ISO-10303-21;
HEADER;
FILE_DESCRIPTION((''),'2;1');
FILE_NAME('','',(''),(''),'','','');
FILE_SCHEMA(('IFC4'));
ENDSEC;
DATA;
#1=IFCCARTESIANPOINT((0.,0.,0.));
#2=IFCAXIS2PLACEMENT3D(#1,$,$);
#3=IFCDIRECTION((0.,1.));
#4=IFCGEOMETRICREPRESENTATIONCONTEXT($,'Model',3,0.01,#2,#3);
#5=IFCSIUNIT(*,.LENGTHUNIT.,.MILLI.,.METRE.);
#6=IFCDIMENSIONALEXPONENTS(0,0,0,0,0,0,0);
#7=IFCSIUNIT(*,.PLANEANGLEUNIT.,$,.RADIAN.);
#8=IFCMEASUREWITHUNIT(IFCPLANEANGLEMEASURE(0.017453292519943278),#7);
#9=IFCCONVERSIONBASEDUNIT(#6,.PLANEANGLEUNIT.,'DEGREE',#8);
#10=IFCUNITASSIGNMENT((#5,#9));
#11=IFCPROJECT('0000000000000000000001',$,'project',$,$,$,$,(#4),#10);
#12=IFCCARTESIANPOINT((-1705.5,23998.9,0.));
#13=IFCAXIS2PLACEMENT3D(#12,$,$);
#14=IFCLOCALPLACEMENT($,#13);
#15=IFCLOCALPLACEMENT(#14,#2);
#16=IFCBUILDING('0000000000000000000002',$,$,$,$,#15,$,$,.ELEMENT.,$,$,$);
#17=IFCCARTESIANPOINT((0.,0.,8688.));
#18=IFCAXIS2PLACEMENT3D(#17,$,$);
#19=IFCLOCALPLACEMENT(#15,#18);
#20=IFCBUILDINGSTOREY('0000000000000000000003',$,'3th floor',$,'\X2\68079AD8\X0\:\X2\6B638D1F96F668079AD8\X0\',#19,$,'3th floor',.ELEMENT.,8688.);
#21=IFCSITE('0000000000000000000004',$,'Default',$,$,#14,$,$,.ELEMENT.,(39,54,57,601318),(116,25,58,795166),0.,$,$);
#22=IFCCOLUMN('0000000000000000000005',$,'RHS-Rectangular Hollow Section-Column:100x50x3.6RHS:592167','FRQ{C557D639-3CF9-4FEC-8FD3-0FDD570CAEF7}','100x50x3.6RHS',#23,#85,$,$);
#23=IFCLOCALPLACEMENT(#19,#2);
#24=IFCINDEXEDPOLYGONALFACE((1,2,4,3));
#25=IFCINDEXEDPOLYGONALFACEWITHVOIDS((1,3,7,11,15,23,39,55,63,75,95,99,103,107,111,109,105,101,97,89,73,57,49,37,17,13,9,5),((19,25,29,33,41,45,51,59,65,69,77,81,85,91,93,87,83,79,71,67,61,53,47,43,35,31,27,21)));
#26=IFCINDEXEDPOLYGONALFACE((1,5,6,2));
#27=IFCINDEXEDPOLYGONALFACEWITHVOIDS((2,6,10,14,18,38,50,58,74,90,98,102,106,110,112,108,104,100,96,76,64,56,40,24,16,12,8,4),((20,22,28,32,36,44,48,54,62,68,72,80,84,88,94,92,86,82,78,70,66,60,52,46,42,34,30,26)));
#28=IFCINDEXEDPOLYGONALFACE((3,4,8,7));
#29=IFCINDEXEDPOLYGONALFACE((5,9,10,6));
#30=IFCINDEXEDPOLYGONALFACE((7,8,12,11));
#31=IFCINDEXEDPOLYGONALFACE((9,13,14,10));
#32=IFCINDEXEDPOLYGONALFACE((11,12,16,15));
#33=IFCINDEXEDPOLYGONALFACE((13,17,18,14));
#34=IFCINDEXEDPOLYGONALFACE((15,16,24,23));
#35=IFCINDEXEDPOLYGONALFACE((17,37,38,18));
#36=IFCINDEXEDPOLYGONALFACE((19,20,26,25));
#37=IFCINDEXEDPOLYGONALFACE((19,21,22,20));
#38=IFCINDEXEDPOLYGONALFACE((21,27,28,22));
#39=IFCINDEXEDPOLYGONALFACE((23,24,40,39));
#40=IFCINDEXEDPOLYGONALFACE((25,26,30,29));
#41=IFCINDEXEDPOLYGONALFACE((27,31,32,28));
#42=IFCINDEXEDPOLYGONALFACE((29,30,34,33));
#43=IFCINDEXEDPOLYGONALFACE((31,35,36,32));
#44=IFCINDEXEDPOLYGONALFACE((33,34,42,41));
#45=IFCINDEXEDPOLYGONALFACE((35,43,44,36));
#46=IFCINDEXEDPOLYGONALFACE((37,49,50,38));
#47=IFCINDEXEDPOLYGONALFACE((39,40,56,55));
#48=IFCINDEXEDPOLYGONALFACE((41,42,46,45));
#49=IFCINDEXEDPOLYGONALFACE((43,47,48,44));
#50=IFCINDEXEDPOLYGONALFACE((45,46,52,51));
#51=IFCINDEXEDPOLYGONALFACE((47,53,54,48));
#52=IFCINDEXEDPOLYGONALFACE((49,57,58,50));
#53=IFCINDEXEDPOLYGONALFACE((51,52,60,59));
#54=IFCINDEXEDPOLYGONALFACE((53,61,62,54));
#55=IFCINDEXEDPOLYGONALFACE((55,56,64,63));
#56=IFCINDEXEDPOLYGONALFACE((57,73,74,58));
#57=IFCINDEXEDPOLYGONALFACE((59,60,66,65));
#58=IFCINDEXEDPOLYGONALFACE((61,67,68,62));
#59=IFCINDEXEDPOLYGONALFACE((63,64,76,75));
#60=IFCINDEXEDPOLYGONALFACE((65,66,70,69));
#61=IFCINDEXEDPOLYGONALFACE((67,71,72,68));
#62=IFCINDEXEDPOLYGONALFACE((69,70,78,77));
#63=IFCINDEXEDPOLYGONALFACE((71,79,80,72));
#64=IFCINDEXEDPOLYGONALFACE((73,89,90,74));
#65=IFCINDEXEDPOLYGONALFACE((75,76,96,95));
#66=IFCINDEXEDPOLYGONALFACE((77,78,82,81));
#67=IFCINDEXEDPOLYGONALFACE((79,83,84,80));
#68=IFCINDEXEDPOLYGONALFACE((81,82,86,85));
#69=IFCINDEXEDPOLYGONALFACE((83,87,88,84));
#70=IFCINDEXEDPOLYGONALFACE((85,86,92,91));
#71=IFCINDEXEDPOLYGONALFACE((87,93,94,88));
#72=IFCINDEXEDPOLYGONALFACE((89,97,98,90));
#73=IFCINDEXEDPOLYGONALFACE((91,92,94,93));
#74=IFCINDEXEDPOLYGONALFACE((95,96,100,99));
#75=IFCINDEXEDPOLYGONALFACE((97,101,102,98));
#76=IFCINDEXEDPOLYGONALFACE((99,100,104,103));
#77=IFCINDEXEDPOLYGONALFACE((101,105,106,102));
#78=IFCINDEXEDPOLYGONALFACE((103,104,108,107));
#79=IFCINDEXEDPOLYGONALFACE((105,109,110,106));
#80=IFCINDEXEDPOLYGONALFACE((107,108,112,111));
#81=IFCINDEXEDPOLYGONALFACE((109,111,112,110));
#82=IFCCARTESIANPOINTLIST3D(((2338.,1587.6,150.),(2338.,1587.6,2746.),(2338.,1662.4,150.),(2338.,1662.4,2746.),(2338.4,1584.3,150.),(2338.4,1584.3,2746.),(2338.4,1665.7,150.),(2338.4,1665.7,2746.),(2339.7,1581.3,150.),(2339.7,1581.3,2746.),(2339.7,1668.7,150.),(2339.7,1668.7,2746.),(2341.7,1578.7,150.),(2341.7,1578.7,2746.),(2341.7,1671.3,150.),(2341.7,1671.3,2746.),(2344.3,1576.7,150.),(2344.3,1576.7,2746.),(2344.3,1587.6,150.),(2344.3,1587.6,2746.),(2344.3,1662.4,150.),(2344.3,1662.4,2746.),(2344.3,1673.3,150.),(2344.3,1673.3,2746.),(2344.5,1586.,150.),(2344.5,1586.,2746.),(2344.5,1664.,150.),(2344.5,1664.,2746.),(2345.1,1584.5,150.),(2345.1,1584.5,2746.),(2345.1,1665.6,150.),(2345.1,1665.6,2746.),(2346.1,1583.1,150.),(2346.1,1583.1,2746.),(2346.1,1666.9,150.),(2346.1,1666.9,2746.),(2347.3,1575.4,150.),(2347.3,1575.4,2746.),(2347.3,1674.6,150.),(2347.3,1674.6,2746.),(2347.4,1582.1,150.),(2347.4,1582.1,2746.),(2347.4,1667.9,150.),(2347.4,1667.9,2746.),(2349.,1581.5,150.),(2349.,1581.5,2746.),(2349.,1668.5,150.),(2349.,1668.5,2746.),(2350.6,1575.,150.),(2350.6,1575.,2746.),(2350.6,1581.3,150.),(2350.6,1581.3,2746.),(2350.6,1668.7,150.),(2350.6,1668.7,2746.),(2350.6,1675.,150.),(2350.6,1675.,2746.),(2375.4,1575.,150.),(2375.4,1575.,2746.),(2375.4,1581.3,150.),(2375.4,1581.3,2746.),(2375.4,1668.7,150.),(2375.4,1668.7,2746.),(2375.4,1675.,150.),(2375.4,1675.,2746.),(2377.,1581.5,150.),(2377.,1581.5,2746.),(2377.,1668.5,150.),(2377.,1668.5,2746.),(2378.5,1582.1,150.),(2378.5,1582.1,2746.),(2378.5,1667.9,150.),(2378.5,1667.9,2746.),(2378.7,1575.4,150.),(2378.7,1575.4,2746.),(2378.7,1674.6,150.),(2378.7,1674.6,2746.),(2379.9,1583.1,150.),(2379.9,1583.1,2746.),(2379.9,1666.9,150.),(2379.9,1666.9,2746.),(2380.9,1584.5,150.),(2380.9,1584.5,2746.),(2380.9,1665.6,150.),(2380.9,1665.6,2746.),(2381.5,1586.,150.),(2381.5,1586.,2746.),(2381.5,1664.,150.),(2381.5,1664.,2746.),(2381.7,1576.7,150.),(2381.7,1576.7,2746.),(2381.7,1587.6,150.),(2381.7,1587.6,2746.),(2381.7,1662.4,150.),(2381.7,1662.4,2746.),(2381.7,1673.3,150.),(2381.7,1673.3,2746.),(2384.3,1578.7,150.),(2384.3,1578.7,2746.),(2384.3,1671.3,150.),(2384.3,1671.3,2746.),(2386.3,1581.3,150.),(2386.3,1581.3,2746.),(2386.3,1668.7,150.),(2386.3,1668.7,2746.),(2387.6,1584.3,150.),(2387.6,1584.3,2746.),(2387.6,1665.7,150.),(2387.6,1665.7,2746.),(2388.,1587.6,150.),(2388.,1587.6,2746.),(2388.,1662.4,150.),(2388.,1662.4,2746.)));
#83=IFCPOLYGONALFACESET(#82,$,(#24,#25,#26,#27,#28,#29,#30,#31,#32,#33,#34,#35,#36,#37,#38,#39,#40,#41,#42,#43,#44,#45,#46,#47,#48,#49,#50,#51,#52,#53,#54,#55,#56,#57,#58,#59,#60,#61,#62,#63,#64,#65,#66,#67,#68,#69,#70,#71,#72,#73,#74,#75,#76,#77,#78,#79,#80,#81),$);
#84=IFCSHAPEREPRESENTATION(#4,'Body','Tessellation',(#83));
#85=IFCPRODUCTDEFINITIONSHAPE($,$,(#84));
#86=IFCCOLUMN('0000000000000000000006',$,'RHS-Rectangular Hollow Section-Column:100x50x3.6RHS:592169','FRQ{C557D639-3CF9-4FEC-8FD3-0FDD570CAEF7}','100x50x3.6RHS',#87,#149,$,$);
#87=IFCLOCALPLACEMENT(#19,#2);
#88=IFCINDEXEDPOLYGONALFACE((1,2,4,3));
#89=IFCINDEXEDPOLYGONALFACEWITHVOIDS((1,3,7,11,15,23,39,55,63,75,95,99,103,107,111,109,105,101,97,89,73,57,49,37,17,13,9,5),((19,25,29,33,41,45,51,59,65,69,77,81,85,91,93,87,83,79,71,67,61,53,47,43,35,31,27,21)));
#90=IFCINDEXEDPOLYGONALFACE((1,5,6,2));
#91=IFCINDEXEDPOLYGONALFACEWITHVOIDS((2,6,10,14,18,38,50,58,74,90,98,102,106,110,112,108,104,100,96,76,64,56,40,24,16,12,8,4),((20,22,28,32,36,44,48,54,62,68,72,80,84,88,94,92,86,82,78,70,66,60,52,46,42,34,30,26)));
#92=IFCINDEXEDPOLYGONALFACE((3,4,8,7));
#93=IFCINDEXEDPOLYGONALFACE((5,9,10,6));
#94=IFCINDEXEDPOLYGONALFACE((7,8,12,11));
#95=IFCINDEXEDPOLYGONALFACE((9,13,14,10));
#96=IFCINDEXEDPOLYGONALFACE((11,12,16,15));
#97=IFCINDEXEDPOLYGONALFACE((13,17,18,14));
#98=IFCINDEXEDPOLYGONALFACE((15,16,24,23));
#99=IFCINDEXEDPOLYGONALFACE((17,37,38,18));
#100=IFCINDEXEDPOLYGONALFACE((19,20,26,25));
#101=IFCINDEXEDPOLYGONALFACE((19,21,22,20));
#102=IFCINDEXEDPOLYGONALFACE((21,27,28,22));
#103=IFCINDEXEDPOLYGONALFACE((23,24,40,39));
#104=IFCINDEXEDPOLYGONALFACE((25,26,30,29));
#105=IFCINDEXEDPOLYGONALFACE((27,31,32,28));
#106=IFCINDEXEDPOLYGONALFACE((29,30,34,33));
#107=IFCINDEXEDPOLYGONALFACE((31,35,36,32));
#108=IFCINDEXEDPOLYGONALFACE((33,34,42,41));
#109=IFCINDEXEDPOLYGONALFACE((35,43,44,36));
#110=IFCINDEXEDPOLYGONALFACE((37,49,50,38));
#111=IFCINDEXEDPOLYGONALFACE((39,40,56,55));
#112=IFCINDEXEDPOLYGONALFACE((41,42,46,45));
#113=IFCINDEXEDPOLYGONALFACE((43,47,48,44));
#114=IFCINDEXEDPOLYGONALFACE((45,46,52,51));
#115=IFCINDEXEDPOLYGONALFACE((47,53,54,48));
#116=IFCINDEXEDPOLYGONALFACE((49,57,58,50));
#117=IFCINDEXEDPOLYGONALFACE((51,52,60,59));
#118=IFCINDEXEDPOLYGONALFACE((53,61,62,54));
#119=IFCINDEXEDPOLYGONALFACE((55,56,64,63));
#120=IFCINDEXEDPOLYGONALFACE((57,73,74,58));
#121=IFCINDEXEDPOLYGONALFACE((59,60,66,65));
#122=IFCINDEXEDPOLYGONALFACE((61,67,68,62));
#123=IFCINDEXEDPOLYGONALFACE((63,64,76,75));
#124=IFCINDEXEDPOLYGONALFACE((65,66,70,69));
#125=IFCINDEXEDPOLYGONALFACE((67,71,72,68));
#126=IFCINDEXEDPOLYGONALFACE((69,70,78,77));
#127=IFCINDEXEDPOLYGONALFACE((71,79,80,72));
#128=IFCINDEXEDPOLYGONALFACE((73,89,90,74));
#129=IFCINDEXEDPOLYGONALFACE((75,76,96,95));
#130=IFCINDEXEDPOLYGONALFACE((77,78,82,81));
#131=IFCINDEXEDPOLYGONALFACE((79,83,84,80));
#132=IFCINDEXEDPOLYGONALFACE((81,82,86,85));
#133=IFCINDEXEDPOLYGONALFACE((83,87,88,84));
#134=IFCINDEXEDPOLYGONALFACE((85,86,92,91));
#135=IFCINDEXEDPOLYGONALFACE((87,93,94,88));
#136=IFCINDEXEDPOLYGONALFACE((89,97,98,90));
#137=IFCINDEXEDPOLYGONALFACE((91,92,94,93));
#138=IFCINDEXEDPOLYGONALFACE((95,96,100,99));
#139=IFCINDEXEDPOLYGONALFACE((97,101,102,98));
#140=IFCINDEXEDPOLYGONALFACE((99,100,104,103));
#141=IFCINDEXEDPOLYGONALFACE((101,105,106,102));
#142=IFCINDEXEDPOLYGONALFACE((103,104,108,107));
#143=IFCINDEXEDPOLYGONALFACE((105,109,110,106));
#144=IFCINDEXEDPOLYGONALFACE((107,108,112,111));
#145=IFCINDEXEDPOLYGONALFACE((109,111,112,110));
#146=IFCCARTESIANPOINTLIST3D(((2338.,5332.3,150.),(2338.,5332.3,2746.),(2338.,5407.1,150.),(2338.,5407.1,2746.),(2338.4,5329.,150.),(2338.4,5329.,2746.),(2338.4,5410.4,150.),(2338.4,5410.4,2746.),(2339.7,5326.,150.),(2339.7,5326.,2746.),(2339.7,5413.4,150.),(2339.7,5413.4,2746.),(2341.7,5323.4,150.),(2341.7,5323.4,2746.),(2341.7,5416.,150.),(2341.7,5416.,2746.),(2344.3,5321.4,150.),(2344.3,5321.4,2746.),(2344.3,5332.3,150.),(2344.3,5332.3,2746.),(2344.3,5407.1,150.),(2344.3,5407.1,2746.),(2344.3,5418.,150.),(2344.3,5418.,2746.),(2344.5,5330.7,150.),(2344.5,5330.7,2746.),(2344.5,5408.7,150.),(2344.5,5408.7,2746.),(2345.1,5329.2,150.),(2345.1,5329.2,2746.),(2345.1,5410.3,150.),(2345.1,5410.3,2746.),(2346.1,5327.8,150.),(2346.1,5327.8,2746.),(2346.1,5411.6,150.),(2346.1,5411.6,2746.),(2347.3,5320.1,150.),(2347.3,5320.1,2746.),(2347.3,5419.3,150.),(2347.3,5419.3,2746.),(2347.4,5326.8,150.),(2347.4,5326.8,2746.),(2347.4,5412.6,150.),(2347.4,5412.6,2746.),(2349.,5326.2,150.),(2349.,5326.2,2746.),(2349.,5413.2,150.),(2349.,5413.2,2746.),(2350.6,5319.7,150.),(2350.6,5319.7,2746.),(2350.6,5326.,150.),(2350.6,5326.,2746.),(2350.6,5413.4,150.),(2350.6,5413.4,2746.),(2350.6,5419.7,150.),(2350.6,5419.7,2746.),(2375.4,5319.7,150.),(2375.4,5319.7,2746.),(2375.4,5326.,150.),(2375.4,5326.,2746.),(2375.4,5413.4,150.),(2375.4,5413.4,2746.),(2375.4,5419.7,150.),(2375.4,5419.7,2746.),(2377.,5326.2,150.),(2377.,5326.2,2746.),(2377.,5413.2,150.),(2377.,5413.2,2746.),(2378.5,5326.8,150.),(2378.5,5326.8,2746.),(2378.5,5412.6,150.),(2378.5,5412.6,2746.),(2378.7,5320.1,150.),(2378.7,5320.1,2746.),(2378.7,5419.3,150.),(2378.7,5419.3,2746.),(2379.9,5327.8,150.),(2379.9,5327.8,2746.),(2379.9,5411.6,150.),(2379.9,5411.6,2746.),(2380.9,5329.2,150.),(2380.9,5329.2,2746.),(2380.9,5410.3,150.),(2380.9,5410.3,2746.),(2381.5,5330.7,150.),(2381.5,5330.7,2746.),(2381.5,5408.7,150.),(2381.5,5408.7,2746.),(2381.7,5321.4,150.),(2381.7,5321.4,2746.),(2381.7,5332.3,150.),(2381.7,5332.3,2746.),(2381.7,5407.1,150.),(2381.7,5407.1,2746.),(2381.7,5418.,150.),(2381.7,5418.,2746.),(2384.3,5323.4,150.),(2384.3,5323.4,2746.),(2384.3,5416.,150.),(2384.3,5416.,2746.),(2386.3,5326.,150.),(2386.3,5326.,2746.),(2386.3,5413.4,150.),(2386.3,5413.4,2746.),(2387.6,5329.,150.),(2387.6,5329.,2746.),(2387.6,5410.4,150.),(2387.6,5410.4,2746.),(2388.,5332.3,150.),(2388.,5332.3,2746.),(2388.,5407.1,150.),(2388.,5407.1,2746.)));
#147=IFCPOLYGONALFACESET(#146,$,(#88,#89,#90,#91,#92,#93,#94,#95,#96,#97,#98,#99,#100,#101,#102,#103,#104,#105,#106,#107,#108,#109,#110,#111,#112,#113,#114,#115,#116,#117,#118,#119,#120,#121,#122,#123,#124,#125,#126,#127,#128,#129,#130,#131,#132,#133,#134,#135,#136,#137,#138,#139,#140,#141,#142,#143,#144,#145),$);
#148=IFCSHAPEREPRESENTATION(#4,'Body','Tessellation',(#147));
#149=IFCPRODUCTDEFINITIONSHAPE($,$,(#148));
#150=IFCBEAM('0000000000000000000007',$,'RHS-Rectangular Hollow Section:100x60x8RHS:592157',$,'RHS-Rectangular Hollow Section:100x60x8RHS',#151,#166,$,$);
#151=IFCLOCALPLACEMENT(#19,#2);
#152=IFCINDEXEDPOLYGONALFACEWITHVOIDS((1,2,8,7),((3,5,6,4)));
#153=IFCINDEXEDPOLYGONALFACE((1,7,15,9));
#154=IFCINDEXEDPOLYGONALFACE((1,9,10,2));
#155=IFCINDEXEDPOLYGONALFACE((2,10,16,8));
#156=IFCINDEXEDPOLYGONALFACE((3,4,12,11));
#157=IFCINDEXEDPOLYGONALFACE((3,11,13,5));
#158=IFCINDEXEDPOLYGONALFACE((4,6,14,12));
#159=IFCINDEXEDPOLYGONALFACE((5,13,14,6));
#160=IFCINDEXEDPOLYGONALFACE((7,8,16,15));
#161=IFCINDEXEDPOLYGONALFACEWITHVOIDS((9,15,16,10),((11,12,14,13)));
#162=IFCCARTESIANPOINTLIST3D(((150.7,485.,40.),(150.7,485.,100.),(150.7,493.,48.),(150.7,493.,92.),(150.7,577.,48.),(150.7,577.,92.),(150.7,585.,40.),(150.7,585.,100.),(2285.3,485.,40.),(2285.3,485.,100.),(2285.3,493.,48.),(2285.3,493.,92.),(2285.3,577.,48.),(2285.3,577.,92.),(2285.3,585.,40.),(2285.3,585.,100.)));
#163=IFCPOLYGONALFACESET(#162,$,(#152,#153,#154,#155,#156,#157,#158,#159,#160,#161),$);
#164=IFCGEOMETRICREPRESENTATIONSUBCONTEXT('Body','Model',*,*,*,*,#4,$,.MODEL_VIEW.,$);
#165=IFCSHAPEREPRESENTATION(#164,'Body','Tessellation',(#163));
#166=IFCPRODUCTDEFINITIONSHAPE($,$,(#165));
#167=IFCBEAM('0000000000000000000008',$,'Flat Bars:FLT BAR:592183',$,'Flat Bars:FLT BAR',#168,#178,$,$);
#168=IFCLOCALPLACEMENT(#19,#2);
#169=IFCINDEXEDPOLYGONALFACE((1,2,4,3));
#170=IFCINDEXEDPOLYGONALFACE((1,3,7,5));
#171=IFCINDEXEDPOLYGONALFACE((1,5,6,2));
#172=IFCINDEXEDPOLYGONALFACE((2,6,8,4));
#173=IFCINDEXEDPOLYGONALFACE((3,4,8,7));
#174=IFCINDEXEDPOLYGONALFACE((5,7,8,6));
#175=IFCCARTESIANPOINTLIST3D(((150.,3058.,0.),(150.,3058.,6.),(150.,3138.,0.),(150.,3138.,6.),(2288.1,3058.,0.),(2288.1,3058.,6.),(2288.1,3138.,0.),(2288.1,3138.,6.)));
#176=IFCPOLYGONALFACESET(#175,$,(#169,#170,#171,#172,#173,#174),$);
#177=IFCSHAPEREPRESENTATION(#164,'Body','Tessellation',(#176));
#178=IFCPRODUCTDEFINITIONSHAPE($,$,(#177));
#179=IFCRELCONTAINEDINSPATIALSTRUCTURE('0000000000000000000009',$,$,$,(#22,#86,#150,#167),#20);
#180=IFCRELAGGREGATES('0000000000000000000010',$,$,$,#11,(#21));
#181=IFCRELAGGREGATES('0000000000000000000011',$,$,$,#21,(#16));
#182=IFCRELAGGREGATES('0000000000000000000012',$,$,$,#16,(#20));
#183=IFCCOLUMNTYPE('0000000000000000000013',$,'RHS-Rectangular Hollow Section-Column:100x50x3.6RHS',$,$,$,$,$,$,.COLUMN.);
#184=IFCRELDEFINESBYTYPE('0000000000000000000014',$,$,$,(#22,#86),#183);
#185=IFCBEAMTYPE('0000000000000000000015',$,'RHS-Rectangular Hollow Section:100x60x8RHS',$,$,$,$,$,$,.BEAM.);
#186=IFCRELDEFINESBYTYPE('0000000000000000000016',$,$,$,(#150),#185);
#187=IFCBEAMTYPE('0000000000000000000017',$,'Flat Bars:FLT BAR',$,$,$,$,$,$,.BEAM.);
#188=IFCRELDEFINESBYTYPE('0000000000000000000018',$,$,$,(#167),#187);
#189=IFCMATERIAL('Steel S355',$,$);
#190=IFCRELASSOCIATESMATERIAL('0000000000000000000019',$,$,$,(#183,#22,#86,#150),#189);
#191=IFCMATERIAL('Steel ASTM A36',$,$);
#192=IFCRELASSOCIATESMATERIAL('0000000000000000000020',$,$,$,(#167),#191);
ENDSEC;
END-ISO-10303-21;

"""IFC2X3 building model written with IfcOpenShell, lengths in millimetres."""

from ifc_helpers import new_model, entity, si_unit, converted_unit, direction, frame, frame_2d, origin, origin_2d, origin_2d_with_axis, place, context, subcontext, project, spatial, rectangle, hollow_rectangle, extrude, boolean, clip, halfspace, material, type_object, element, save


model = new_model("IFC2X3")

# Units and contexts
model_context = context("Model", 3, precision=0.01, world=origin(), true_north=direction((0.0, 1.0)))
body_context = subcontext(model_context, "Body", "Model", "MODEL_VIEW")
ifc_project = project(units=[si_unit("LENGTHUNIT", "METRE", prefix="MILLI"), converted_unit("PLANEANGLEUNIT", "DEGREE", entity("IfcPlaneAngleMeasure", 0.017453292519943278), si_unit("PLANEANGLEUNIT", "RADIAN"), dimensions=[0, 0, 0, 0, 0, 0, 0])], contexts=[model_context])

# Site, building, storey
site_placement = place(None, frame((-1705.5, 23998.9, 0.0)))
site = spatial("IfcSite", under=ifc_project, at=site_placement, Name="Default", CompositionType="ELEMENT", RefLatitude=(39, 54, 57, 601318), RefLongitude=(116, 25, 58, 795166), RefElevation=0.0)
building_placement = place(site_placement, origin())
building = spatial("IfcBuilding", under=site, at=building_placement, CompositionType="ELEMENT")
storey_placement = place(building_placement, frame((0.0, 0.0, 8688.0)))
storey = spatial("IfcBuildingStorey", under=building, at=storey_placement, Name="3th floor", ObjectType="标高:正负零标高", LongName="3th floor", CompositionType="ELEMENT", Elevation=8688.0)

# Shared definitions
ifc_material_1 = material(Name="Steel S355")

# Columns
column_type_1 = type_object("IfcColumnType", Name="RHS-Rectangular Hollow Section-Column:100x50x3.6RHS", PredefinedType="COLUMN", material=ifc_material_1)
column_1_placement = place(storey_placement, frame((2363.0, 1625.0, 2746.0), z_axis=(0.0, 0.0, 1.0), x_axis=(-1.0, 0.0, 0.0)))
element("IfcColumn", 1, at=column_1_placement, inside=storey, type_object=column_type_1, material=ifc_material_1, Name="RHS-Rectangular Hollow Section-Column:100x50x3.6RHS:592167", Description="FRQ{C557D639-3CF9-4FEC-8FD3-0FDD570CAEF7}", ObjectType="100x50x3.6RHS", context=model_context, shape_type="Clipping", body=[
    clip(extrude(hollow_rectangle(XDim=50.0, YDim=100.0, WallThickness=6.3, InnerFilletRadius=6.3, OuterFilletRadius=12.6, at=origin_2d()), origin(), (0.0, 0.0, -1.0), 2651.9), halfspace(frame((2363.0, 1625.0, -2596.0), z_axis=(0.0, 0.0, 1.0), x_axis=(-1.0, 0.0, 0.0)), True)),
])
column_2_placement = place(storey_placement, frame((2363.0, 5369.7, 2746.0), z_axis=(0.0, 0.0, 1.0), x_axis=(-1.0, 0.0, 0.0)))
element("IfcColumn", 2, at=column_2_placement, inside=storey, type_object=column_type_1, material=ifc_material_1, Name="RHS-Rectangular Hollow Section-Column:100x50x3.6RHS:592169", Description="FRQ{C557D639-3CF9-4FEC-8FD3-0FDD570CAEF7}", ObjectType="100x50x3.6RHS", context=model_context, shape_type="Clipping", body=[
    clip(extrude(hollow_rectangle(XDim=50.0, YDim=100.0, WallThickness=6.3, InnerFilletRadius=6.3, OuterFilletRadius=12.6, at=origin_2d()), origin(), (0.0, 0.0, -1.0), 2651.9), halfspace(frame((2363.0, 5369.7, -2596.0), z_axis=(0.0, 0.0, 1.0), x_axis=(-1.0, 0.0, 0.0)), True)),
])

# Beams
beam_type_1 = type_object("IfcBeamType", Name="RHS-Rectangular Hollow Section:100x60x8RHS", PredefinedType="BEAM")
beam_1_placement = place(storey_placement, frame((150.7, 585.0, 70.0)))
element("IfcBeam", 3, at=beam_1_placement, inside=storey, type_object=beam_type_1, material=ifc_material_1, Name="RHS-Rectangular Hollow Section:100x60x8RHS:592157", ObjectType="RHS-Rectangular Hollow Section:100x60x8RHS", context=body_context, shape_type="SweptSolid", body=[
    boolean("DIFFERENCE", extrude(rectangle(XDim=60.0, YDim=100.0, at=frame_2d((0.0, 0.0), x_axis=(1.0, 0.0))), frame((0.0, -50.0, 0.0), z_axis=(1.0, 0.0, 0.0), x_axis=(0.0, 0.0, -1.0)), (0.0, 0.0, 1.0), 2134.6), extrude(rectangle(XDim=44.0, YDim=84.0, at=frame_2d((0.0, 0.0), x_axis=(0.0, 1.0))), frame((2134.6, -50.0, 0.0), z_axis=(-1.0, 0.0, 0.0), x_axis=(0.0, 1.0, 0.0)), (0.0, 0.0, 1.0), 2134.6)),
])
ifc_material_2 = material(Name="Steel ASTM A36")
beam_type_2 = type_object("IfcBeamType", Name="Flat Bars:FLT BAR", PredefinedType="BEAM")
beam_2_placement = place(storey_placement, frame((150.0, 3098.0, 6.0)))
element("IfcBeam", 4, at=beam_2_placement, inside=storey, type_object=beam_type_2, material=ifc_material_2, Name="Flat Bars:FLT BAR:592183", ObjectType="Flat Bars:FLT BAR", context=body_context, shape_type="SweptSolid", body=[
    extrude(rectangle(XDim=6.0, YDim=80.0, at=origin_2d_with_axis()), frame((0.0, 0.0, -3.0), z_axis=(1.0, 0.0, 0.0), x_axis=(0.0, 0.0, -1.0)), (0.0, 0.0, 1.0), 2138.1),
])

save(model, "model.ifc")
